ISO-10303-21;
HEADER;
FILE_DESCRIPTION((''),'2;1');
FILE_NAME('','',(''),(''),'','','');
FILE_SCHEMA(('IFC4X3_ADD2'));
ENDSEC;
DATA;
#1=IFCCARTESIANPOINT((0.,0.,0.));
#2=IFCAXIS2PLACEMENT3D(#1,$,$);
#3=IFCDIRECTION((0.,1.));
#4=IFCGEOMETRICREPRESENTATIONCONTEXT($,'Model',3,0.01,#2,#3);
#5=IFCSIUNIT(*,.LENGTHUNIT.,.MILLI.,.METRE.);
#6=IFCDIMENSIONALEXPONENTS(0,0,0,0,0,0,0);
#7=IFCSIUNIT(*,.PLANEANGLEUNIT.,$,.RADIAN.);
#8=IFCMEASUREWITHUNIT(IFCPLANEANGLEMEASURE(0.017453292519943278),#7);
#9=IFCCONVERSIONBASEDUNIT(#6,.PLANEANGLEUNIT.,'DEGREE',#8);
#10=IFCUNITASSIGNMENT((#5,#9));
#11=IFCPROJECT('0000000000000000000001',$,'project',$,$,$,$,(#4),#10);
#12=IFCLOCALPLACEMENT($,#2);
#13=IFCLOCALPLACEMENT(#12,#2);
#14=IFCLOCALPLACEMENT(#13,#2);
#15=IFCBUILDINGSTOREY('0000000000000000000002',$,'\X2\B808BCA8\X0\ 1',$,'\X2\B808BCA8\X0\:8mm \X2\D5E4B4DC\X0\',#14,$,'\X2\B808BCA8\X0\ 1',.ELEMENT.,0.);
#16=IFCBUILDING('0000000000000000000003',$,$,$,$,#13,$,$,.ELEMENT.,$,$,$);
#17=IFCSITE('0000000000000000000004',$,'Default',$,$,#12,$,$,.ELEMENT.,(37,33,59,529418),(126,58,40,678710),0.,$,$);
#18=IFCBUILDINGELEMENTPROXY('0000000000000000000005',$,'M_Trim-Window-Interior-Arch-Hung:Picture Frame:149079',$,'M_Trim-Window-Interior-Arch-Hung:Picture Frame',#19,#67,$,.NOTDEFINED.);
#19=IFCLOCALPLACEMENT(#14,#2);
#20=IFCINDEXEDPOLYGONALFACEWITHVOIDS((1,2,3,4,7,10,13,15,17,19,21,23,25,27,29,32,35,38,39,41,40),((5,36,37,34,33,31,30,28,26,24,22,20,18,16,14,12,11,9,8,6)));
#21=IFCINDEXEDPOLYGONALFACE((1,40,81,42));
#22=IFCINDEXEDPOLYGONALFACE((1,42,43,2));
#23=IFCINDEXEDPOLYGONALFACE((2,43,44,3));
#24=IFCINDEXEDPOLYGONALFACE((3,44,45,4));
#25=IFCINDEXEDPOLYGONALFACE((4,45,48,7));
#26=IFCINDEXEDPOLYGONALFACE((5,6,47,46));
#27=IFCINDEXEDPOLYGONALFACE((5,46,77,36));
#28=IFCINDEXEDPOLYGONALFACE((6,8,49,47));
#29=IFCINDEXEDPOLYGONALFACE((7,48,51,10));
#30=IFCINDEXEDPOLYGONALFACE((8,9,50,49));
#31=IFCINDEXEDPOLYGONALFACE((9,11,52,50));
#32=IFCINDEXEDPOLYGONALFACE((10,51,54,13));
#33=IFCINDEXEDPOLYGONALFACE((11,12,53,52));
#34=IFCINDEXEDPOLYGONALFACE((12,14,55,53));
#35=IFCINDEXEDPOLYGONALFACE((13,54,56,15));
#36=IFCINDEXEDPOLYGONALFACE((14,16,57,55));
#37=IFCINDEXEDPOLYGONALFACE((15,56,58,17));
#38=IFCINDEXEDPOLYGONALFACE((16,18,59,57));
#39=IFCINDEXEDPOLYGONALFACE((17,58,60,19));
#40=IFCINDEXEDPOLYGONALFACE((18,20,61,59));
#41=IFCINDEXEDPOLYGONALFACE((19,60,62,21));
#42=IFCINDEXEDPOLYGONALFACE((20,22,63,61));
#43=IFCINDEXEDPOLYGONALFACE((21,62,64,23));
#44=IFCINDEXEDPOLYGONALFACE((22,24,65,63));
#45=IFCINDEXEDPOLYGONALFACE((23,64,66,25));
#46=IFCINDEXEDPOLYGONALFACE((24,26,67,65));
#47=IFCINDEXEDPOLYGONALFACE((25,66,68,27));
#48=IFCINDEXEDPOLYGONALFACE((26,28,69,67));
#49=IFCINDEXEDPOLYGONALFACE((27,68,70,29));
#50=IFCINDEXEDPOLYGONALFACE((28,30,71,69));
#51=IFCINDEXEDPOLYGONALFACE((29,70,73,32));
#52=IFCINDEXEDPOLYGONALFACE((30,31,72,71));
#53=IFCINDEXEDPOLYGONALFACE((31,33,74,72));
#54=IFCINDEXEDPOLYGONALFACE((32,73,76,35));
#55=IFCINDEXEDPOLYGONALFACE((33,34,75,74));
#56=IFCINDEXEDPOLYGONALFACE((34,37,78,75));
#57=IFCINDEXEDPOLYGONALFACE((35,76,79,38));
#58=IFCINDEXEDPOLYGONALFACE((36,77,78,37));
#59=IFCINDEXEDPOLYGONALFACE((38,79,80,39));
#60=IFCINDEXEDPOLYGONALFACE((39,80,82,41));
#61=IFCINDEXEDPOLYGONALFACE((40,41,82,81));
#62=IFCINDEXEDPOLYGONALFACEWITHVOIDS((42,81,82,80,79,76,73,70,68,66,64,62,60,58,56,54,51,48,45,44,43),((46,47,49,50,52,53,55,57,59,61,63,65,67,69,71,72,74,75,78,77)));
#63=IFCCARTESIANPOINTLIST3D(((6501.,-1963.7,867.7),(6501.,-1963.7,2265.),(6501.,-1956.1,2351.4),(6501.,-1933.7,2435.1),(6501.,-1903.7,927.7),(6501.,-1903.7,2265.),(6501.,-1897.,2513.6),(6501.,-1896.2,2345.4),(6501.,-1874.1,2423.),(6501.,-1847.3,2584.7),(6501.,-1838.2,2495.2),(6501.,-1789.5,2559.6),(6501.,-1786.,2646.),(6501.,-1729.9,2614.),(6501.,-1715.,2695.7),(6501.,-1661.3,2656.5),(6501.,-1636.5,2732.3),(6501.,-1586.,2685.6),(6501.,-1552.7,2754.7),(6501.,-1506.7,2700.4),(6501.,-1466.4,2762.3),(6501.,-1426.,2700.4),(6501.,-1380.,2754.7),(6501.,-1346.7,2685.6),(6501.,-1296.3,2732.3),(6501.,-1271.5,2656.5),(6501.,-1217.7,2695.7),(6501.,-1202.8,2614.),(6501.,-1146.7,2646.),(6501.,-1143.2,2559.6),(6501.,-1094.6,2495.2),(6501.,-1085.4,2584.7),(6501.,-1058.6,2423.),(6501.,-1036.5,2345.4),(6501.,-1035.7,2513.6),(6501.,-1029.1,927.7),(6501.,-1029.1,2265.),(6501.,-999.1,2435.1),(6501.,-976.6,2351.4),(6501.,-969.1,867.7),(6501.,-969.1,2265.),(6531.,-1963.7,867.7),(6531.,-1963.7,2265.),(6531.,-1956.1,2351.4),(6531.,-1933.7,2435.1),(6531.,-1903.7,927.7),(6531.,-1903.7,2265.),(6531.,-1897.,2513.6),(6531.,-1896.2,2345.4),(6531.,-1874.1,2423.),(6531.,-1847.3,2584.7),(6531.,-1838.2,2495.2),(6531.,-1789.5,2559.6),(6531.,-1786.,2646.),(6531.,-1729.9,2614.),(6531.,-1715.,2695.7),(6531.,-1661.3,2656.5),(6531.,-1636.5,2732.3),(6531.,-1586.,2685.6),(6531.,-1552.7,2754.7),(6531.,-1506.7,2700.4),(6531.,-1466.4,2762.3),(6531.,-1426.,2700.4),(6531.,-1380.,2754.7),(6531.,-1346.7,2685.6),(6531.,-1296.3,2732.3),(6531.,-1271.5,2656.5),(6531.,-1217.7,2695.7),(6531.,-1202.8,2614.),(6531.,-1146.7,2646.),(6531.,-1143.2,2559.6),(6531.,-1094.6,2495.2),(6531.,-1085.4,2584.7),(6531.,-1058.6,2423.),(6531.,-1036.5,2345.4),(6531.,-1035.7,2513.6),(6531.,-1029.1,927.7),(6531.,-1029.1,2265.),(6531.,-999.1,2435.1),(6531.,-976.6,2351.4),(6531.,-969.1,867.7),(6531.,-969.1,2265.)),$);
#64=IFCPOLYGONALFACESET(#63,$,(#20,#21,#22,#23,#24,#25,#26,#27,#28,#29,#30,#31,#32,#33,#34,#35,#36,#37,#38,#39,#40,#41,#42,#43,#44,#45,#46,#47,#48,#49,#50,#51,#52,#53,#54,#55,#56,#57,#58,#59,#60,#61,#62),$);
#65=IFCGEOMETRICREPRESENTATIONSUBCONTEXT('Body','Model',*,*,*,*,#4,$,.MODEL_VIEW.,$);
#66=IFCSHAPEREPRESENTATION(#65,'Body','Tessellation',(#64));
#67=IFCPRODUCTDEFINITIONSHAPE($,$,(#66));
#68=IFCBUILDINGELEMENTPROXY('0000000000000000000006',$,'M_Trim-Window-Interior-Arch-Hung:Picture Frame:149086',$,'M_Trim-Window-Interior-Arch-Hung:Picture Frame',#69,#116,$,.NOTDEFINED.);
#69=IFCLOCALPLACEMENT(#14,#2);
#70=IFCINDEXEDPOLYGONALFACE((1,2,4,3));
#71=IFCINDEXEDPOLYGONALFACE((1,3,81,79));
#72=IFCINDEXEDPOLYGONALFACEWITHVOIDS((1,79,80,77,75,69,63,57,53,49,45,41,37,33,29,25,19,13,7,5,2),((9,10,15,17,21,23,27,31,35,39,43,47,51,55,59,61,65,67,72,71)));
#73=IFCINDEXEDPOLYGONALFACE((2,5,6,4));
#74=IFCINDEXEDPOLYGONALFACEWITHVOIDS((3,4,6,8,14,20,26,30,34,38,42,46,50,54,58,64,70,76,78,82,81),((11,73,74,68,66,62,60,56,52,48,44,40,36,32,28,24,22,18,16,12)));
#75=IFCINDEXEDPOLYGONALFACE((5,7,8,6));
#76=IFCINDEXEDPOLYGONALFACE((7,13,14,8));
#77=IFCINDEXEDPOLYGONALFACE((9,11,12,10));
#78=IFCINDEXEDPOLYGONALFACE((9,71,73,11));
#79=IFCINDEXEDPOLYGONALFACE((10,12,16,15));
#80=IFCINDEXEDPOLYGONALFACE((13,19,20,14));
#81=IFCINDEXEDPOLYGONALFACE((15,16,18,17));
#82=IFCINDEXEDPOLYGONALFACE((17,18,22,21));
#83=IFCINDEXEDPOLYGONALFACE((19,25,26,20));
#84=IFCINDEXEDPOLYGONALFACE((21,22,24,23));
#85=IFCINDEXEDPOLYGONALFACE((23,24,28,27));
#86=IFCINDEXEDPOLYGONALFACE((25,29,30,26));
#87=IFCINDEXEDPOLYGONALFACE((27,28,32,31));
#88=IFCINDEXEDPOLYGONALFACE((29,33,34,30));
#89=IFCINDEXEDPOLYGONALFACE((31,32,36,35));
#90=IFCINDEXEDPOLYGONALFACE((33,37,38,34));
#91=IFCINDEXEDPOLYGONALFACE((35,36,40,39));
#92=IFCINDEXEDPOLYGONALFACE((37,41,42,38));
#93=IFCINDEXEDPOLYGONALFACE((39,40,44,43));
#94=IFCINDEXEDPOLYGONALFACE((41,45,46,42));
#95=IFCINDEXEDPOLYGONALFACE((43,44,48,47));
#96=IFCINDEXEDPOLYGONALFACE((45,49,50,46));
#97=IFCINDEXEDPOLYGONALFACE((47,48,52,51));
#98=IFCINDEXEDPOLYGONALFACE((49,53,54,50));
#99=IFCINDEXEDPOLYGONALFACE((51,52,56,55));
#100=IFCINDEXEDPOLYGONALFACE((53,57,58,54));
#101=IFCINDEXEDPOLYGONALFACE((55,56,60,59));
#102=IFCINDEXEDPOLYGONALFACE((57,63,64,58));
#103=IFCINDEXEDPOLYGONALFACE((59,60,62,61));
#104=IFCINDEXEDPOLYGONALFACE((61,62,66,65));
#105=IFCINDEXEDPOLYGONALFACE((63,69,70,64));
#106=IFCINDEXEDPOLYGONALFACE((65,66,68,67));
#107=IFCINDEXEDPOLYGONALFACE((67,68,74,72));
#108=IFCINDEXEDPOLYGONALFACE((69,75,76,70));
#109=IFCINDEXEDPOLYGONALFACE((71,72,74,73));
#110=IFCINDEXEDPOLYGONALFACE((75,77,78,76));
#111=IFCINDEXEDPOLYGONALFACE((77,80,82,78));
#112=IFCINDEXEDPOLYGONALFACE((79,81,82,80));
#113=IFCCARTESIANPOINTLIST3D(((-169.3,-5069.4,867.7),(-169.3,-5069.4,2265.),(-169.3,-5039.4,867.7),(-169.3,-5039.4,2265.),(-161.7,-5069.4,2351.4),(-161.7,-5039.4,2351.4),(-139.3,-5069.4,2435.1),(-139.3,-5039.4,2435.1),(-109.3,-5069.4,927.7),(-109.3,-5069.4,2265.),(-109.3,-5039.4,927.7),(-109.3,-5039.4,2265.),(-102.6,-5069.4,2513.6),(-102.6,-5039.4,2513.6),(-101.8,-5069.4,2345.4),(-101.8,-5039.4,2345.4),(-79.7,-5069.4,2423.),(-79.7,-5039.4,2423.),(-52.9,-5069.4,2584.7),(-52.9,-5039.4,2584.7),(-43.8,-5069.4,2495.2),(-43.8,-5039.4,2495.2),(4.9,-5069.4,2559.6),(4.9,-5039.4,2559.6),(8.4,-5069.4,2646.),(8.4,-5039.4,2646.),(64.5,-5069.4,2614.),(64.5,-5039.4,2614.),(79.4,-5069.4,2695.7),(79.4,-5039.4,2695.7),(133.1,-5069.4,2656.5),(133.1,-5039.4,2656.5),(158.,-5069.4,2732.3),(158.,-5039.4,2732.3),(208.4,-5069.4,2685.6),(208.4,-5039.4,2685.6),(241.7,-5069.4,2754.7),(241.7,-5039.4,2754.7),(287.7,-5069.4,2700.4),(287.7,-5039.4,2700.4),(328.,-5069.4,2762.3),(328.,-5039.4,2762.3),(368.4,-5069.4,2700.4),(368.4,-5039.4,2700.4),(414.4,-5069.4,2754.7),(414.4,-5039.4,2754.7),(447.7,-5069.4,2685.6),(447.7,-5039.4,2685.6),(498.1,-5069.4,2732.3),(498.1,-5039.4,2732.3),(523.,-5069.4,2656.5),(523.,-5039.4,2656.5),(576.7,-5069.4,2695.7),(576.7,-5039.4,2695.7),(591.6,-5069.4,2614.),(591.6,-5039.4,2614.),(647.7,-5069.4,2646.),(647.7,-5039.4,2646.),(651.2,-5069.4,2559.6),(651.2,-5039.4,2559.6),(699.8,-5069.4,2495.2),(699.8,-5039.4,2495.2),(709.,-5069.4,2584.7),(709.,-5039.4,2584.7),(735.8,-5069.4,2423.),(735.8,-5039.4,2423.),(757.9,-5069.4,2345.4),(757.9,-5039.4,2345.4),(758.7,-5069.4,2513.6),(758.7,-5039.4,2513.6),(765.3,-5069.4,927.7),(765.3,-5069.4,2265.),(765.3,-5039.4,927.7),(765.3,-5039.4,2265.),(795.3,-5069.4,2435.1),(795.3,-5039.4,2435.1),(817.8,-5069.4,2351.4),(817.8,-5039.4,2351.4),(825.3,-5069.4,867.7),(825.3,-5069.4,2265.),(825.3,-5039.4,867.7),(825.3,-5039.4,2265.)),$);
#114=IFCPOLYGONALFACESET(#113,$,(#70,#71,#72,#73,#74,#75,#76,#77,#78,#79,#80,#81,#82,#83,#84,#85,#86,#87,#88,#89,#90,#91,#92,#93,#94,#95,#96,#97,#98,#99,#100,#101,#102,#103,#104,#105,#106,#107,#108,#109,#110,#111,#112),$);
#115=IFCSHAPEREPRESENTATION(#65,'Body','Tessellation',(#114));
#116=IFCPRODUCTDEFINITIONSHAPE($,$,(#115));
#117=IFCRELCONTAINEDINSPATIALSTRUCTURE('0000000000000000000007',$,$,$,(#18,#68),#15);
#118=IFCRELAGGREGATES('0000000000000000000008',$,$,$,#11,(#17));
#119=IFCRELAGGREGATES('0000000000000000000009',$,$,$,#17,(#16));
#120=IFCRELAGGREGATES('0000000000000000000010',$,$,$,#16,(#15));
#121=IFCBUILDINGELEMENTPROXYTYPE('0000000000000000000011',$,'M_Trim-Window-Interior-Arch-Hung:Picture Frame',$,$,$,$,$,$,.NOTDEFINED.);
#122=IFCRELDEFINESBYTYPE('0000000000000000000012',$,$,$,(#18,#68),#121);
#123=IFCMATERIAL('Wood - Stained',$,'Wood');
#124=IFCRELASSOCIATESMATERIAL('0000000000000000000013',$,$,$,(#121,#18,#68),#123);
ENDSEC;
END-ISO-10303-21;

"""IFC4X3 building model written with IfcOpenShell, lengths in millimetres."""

from ifc_helpers import new_model, entity, si_unit, converted_unit, direction, frame, frame_2d, origin, place, context, subcontext, project, spatial, polyline, circle_curve, parameter, trimmed, segment, composite_curve, outline, extrude, source, transform, mapped, material, type_object, type_shapes, element, save


model = new_model("IFC4X3")

# Units and contexts
model_context = context("Model", 3, precision=0.01, world=origin(), true_north=direction((0.0, 1.0)))
body_context = subcontext(model_context, "Body", "Model", "MODEL_VIEW")
ifc_project = project(units=[si_unit("LENGTHUNIT", "METRE", prefix="MILLI"), converted_unit("PLANEANGLEUNIT", "DEGREE", entity("IfcPlaneAngleMeasure", 0.017453292519943278), si_unit("PLANEANGLEUNIT", "RADIAN"), dimensions=[0, 0, 0, 0, 0, 0, 0])], contexts=[model_context])

# Site, building, storey
site_placement = place(None, origin())
site = spatial("IfcSite", under=ifc_project, at=site_placement, Name="Default", CompositionType="ELEMENT", RefLatitude=(37, 33, 59, 529418), RefLongitude=(126, 58, 40, 678710), RefElevation=0.0)
building_placement = place(site_placement, origin())
building = spatial("IfcBuilding", under=site, at=building_placement, CompositionType="ELEMENT")
storey_placement = place(building_placement, origin())
storey = spatial("IfcBuildingStorey", under=building, at=storey_placement, Name="레벨 1", ObjectType="레벨:8mm 헤드", LongName="레벨 1", CompositionType="ELEMENT", Elevation=0.0)

# Building element proxies
ifc_material_1 = material(Name="Wood - Stained", Category="Wood")
building_element_proxy_type_1 = type_object("IfcBuildingElementProxyType", Name="M_Trim-Window-Interior-Arch-Hung:Picture Frame", PredefinedType="NOTDEFINED", material=ifc_material_1)
shared_shape_1 = source(origin(), body_context, "Body", "SweptSolid", [
    extrude(outline(composite_curve([segment(polyline([(-698.7, -497.3), (698.7, -497.3)]), True, "CONTINUOUS"), segment(polyline([(698.7, -497.3), (698.7, 497.3)]), True, "CONTINUOUS"), segment(polyline([(698.7, 497.3), (-698.7, 497.3)]), True, "CONTINUOUS"), segment(trimmed(circle_curve(frame_2d((-698.7, 0.0), x_axis=(0.0, 1.0)), 497.3), [parameter(0.0)], [parameter(180.0)], True, "PARAMETER"), True, "CONTINUOUS")], self_intersect=False), holes=[composite_curve([segment(trimmed(circle_curve(frame_2d((-698.7, 0.0), x_axis=(0.0, 1.0)), 437.3), [parameter(0.0)], [parameter(180.0)], True, "PARAMETER"), False, "CONTINUOUS"), segment(polyline([(-698.7, 437.3), (638.6, 437.3)]), True, "CONTINUOUS"), segment(polyline([(638.6, 437.3), (638.7, -437.3)]), True, "CONTINUOUS"), segment(polyline([(638.7, -437.3), (-698.7, -437.3)]), True, "CONTINUOUS")], self_intersect=False)]), frame((0.0, -1148.7, 0.0), z_axis=(0.0, 0.0, 1.0), x_axis=(0.0, -1.0, 0.0)), (0.0, 0.0, 1.0), 30.0),
])
type_shapes(building_element_proxy_type_1, [shared_shape_1])
for number, where, z_axis, x_axis, name in (
    (1, (6531.0, -1466.4, 2715.0), (-1.0, 0.0, 0.0), (0.0, -1.0, 0.0), "M_Trim-Window-Interior-Arch-Hung:Picture Frame:149079"),
    (2, (328.0, -5069.4, 2715.0), (0.0, 1.0, 0.0), (-1.0, 0.0, 0.0), "M_Trim-Window-Interior-Arch-Hung:Picture Frame:149086"),
):
    element("IfcBuildingElementProxy", number, at=place(storey_placement, frame(where, z_axis=z_axis, x_axis=x_axis)), inside=storey, type_object=building_element_proxy_type_1, material=ifc_material_1, Name=name, ObjectType="M_Trim-Window-Interior-Arch-Hung:Picture Frame", PredefinedType="NOTDEFINED", context=body_context, shape_type="MappedRepresentation", body=[
        mapped(shared_shape_1, transform((0.0, 0.0, 0.0), scale=1.0)),
    ])

save(model, "model.ifc")
